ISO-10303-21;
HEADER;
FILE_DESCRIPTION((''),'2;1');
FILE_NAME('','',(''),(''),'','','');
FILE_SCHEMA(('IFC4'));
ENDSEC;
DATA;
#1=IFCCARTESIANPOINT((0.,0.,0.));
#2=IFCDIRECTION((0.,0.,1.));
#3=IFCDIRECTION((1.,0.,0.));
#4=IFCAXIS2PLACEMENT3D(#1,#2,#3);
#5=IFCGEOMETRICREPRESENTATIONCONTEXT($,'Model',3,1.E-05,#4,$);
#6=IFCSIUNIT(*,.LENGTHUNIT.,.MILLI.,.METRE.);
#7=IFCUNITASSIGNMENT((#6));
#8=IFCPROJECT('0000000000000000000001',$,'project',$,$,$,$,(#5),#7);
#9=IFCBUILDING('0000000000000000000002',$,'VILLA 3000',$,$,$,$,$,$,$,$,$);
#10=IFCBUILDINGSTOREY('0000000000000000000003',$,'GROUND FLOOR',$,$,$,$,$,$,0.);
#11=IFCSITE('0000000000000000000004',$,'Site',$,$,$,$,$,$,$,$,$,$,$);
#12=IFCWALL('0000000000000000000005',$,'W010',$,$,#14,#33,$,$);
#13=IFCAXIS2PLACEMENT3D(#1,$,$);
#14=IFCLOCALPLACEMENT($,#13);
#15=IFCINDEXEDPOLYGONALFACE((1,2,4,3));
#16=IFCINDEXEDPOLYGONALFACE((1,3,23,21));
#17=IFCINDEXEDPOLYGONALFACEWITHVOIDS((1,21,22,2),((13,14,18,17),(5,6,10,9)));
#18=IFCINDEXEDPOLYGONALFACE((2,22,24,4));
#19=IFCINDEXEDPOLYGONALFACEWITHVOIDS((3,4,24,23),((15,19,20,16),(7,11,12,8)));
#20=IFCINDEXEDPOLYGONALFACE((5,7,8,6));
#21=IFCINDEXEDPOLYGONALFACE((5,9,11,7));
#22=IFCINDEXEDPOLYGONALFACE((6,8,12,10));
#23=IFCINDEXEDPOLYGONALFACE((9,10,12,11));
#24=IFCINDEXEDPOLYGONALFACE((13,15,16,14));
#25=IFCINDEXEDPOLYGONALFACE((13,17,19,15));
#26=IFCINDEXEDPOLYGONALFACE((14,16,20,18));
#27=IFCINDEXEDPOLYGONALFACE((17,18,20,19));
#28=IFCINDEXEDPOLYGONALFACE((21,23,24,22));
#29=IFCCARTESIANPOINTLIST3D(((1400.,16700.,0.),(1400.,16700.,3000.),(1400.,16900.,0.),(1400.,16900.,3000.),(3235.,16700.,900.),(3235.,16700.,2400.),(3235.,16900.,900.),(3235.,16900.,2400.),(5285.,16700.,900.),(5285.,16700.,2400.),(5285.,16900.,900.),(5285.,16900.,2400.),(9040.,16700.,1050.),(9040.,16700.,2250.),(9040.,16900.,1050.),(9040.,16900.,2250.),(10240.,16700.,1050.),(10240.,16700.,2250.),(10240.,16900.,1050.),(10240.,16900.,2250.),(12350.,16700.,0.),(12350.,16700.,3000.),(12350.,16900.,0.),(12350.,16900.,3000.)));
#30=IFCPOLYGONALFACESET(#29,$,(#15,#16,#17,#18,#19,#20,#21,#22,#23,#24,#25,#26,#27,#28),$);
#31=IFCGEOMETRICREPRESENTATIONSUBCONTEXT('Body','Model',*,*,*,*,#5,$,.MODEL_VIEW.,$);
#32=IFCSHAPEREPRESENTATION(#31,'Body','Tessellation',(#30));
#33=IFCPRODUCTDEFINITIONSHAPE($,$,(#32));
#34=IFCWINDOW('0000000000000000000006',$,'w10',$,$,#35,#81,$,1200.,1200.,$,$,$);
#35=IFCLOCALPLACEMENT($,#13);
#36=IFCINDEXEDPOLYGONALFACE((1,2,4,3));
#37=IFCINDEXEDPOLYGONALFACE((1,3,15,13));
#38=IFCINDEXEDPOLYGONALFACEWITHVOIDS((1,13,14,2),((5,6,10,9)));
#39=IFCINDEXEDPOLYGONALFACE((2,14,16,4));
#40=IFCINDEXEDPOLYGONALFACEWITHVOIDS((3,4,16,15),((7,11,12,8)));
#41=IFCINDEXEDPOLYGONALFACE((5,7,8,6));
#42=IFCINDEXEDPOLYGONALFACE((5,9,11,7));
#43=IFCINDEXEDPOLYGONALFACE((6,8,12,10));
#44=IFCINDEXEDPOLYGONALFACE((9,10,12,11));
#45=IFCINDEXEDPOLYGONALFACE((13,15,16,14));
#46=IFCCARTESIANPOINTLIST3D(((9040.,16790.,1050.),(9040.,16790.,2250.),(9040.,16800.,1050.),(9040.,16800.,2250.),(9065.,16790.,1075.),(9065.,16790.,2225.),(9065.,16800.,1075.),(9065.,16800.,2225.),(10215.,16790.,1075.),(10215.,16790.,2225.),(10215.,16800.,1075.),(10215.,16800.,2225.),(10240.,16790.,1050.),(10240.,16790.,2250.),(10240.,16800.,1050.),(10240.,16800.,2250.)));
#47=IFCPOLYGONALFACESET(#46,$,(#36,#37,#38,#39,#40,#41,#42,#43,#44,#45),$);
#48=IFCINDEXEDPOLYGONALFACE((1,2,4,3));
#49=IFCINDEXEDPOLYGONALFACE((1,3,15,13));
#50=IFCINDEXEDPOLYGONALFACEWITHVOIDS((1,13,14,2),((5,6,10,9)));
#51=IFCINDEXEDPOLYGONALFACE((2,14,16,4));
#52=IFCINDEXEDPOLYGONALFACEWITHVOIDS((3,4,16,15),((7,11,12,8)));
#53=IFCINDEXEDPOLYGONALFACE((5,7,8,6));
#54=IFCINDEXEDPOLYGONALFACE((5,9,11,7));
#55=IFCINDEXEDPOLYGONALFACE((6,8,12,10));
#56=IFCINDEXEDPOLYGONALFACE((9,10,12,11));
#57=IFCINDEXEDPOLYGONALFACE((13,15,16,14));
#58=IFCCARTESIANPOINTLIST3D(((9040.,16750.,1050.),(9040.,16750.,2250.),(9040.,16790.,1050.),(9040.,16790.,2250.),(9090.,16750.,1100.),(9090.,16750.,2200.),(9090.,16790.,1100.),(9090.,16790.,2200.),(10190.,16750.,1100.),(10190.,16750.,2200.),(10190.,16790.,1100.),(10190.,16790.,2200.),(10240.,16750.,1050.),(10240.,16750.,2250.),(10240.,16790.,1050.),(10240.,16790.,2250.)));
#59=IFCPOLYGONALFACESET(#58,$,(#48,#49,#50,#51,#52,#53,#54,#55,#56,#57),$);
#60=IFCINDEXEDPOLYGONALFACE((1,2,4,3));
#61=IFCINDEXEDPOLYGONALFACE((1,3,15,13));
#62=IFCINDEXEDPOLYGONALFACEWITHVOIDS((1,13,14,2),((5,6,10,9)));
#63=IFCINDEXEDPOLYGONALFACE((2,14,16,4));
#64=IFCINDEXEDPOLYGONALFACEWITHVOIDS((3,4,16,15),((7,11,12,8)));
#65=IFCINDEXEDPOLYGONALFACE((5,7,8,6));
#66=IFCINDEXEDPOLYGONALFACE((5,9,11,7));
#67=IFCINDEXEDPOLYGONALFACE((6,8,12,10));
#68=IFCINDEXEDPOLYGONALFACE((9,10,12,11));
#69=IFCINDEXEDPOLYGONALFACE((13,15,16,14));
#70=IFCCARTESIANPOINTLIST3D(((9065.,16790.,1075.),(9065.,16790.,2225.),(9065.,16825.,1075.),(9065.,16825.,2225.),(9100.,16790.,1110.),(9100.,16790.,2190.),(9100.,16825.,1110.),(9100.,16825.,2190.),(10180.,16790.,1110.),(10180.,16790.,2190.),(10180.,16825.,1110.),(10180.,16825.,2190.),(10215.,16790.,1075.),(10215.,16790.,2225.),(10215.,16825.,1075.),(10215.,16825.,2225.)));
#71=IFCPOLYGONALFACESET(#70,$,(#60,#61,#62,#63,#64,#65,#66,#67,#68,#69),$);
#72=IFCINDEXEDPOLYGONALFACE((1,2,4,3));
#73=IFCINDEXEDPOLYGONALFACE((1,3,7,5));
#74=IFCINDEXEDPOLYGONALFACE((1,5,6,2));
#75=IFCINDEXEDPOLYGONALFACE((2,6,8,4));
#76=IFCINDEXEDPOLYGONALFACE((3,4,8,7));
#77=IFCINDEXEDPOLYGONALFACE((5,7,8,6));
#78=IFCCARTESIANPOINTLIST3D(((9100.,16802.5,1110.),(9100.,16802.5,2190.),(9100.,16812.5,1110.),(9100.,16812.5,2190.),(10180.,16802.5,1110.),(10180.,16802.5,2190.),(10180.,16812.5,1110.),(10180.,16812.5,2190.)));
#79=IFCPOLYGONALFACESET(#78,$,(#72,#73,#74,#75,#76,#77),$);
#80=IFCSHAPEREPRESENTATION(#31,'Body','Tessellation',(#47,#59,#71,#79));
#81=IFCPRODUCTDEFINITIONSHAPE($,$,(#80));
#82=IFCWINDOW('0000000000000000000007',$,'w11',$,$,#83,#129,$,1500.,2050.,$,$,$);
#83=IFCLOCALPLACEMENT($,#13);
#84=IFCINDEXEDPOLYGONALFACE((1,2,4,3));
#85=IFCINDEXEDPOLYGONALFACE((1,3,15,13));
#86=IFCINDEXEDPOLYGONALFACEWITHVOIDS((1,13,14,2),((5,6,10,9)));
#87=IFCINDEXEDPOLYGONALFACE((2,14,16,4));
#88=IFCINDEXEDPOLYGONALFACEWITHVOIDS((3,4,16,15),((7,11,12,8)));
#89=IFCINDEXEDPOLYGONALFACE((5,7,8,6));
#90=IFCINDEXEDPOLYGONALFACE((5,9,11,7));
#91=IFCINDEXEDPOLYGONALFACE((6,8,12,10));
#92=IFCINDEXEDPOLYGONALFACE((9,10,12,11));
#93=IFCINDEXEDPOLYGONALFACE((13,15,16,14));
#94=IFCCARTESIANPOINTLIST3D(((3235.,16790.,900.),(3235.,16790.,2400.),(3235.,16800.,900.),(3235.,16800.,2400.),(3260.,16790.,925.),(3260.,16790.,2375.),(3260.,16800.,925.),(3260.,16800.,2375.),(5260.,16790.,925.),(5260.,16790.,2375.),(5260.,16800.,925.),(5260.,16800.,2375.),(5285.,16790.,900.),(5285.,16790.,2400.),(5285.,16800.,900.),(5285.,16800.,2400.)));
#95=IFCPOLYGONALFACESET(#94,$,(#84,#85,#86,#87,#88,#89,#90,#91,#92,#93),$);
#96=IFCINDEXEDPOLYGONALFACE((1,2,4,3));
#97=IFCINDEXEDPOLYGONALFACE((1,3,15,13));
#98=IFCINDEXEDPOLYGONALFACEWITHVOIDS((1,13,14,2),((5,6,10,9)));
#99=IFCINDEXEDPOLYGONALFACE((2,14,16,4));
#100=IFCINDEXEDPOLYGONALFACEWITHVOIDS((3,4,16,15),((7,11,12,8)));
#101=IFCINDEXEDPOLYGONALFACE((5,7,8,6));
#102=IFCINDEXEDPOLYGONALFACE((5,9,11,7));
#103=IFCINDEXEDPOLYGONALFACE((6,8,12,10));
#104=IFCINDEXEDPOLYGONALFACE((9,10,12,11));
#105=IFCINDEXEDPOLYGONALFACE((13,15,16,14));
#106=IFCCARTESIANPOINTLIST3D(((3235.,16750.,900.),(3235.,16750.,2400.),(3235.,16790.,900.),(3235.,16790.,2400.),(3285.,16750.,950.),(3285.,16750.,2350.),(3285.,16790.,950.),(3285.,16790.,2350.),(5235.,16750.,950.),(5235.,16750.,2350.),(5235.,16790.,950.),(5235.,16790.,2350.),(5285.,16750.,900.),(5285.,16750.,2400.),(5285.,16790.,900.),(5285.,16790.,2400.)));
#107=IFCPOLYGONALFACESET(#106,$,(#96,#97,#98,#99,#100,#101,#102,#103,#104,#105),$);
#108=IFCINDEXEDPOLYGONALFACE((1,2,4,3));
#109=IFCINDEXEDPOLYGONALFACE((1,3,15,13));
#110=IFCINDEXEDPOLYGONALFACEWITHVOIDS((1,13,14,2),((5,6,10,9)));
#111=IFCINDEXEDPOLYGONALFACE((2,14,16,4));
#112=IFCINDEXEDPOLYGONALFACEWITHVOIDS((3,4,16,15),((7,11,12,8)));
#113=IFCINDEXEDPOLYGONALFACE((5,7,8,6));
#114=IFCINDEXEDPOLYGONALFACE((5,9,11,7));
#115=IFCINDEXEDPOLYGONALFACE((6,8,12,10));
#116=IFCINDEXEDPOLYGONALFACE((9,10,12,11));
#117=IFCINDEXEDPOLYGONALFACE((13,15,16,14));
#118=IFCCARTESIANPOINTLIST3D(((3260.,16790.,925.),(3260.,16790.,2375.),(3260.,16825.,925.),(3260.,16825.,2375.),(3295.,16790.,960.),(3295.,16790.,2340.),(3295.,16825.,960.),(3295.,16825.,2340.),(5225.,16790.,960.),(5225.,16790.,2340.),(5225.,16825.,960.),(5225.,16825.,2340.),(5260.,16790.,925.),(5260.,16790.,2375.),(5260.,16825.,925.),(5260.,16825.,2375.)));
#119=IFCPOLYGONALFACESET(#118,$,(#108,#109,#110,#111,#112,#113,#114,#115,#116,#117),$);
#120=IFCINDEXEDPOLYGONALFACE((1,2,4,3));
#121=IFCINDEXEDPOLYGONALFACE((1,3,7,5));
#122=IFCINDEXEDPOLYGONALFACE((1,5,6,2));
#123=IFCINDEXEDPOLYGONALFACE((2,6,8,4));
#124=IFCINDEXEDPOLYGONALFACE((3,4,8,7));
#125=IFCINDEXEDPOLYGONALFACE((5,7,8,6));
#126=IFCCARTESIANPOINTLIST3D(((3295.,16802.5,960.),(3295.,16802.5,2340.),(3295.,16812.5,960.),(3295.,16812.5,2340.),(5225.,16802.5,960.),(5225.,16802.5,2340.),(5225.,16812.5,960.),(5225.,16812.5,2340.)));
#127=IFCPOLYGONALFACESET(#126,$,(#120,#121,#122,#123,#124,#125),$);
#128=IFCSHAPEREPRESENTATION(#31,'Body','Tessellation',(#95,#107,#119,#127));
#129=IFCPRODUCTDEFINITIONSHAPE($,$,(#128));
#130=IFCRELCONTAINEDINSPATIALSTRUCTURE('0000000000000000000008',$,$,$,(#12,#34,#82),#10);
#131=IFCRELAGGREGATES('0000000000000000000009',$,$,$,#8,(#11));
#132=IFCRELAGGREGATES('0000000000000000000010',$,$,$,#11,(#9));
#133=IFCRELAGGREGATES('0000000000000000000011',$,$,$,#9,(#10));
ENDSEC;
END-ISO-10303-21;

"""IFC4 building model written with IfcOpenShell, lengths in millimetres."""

from ifc_helpers import new_model, si_unit, frame, origin_with_axes, place, context, subcontext, project, spatial, line, indexed_curve, outline, extrude, element, fill, save


model = new_model("IFC4")

# Units and contexts
model_context = context("Model", 3, precision=1e-05, world=origin_with_axes())
body_context = subcontext(model_context, "Body", "Model", "MODEL_VIEW")
ifc_project = project(units=[si_unit("LENGTHUNIT", "METRE", prefix="MILLI")], contexts=[model_context])

# Site, building, storey
site = spatial("IfcSite", under=ifc_project, Name="Site")
building = spatial("IfcBuilding", under=site, Name="VILLA 3000")
storey = spatial("IfcBuildingStorey", under=building, Name="GROUND FLOOR", Elevation=0.0)

# Wall, openings, windows
wall_1_placement = place(None, frame((1400.0, 16800.0, 0.0), z_axis=(0.0, 0.0, 1.0), x_axis=(1.0, 0.0, 0.0)))
wall_1 = element("IfcWall", 1, at=wall_1_placement, inside=storey, Name="W010", context=body_context, shape_type="SweptSolid", body=[
    extrude(outline(indexed_curve([(0.0, 0.0), (0.0, 200.0), (10950.0, 200.0), (10950.0, 0.0), (0.0, 0.0)], self_intersect=False)), frame((0.0, -100.0, 0.0), z_axis=(0.0, 0.0, 1.0), x_axis=(1.0, 0.0, 0.0)), (0.0, 0.0, 1.0), 3000.0),
])
opening_1_placement = place(wall_1_placement, frame((7640.0, 0.0, 1050.0), z_axis=(0.0, 0.0, 1.0), x_axis=(1.0, 0.0, 0.0)))
opening_1 = element("IfcOpeningElement", 2, at=opening_1_placement, cuts=wall_1, context=body_context, shape_type="SweptSolid", body=[
    extrude(outline(indexed_curve([(0.0, 0.0), (0.0, 300.0), (1200.0, 300.0), (1200.0, 0.0), (0.0, 0.0)], self_intersect=False)), frame((0.0, -150.0, 0.0), z_axis=(0.0, 0.0, 1.0), x_axis=(1.0, 0.0, 0.0)), (0.0, 0.0, 1.0), 1200.0),
])
opening_2_placement = place(wall_1_placement, frame((1835.0, 0.0, 900.0), z_axis=(0.0, 0.0, 1.0), x_axis=(1.0, 0.0, 0.0)))
opening_2 = element("IfcOpeningElement", 3, at=opening_2_placement, cuts=wall_1, context=body_context, shape_type="SweptSolid", body=[
    extrude(outline(indexed_curve([(0.0, 0.0), (0.0, 300.0), (2050.0, 300.0), (2050.0, 0.0), (0.0, 0.0)], self_intersect=False)), frame((0.0, -150.0, 0.0), z_axis=(0.0, 0.0, 1.0), x_axis=(1.0, 0.0, 0.0)), (0.0, 0.0, 1.0), 1500.0),
])
window_1_placement = place(None, frame((9040.0, 16700.0, 1050.0), z_axis=(0.0, 0.0, 1.0), x_axis=(1.0, 0.0, 0.0)))
window_1 = element("IfcWindow", 4, at=window_1_placement, inside=storey, Name="w10", OverallHeight=1200.0, OverallWidth=1200.0, context=body_context, shape_type="SweptSolid", body=[
    extrude(outline(indexed_curve([(0.0, 0.0), (1200.0, 0.0), (1200.0, 1200.0), (0.0, 1200.0)], segments=[line(1, 2, 3, 4, 1)]), holes=[indexed_curve([(25.0, 25.0), (1175.0, 25.0), (1175.0, 1175.0), (25.0, 1175.0)], segments=[line(1, 2, 3, 4, 1)])]), frame((0.0, 90.0, 0.0), z_axis=(0.0, -1.0, 0.0), x_axis=(1.0, 0.0, 0.0)), (0.0, 0.0, -1.0), 10.0),
    extrude(outline(indexed_curve([(0.0, 0.0), (1200.0, 0.0), (1200.0, 1200.0), (0.0, 1200.0)], segments=[line(1, 2, 3, 4, 1)]), holes=[indexed_curve([(50.0, 50.0), (1150.0, 50.0), (1150.0, 1150.0), (50.0, 1150.0)], segments=[line(1, 2, 3, 4, 1)])]), frame((0.0, 50.0, 0.0), z_axis=(0.0, -1.0, 0.0), x_axis=(1.0, 0.0, 0.0)), (0.0, 0.0, -1.0), 40.0),
    extrude(outline(indexed_curve([(0.0, 0.0), (1150.0, 0.0), (1150.0, 1150.0), (0.0, 1150.0)], segments=[line(1, 2, 3, 4, 1)]), holes=[indexed_curve([(35.0, 35.0), (1115.0, 35.0), (1115.0, 1115.0), (35.0, 1115.0)], segments=[line(1, 2, 3, 4, 1)])]), frame((25.0, 90.0, 25.0), z_axis=(0.0, -1.0, 0.0), x_axis=(1.0, 0.0, 0.0)), (0.0, 0.0, -1.0), 35.0),
    extrude(outline(indexed_curve([(35.0, 35.0), (1115.0, 35.0), (1115.0, 1115.0), (35.0, 1115.0)], segments=[line(1, 2, 3, 4, 1)])), frame((25.0, 102.5, 25.0), z_axis=(0.0, -1.0, 0.0), x_axis=(1.0, 0.0, 0.0)), (0.0, 0.0, -1.0), 10.0),
])
fill(opening_1, window_1)
window_2_placement = place(None, frame((3235.0, 16700.0, 900.0), z_axis=(0.0, 0.0, 1.0), x_axis=(1.0, 0.0, 0.0)))
window_2 = element("IfcWindow", 5, at=window_2_placement, inside=storey, Name="w11", OverallHeight=1500.0, OverallWidth=2050.0, context=body_context, shape_type="SweptSolid", body=[
    extrude(outline(indexed_curve([(0.0, 0.0), (2050.0, 0.0), (2050.0, 1500.0), (0.0, 1500.0)], segments=[line(1, 2, 3, 4, 1)]), holes=[indexed_curve([(25.0, 25.0), (2025.0, 25.0), (2025.0, 1475.0), (25.0, 1475.0)], segments=[line(1, 2, 3, 4, 1)])]), frame((0.0, 90.0, 0.0), z_axis=(0.0, -1.0, 0.0), x_axis=(1.0, 0.0, 0.0)), (0.0, 0.0, -1.0), 10.0),
    extrude(outline(indexed_curve([(0.0, 0.0), (2050.0, 0.0), (2050.0, 1500.0), (0.0, 1500.0)], segments=[line(1, 2, 3, 4, 1)]), holes=[indexed_curve([(50.0, 50.0), (2000.0, 50.0), (2000.0, 1450.0), (50.0, 1450.0)], segments=[line(1, 2, 3, 4, 1)])]), frame((0.0, 50.0, 0.0), z_axis=(0.0, -1.0, 0.0), x_axis=(1.0, 0.0, 0.0)), (0.0, 0.0, -1.0), 40.0),
    extrude(outline(indexed_curve([(0.0, 0.0), (2000.0, 0.0), (2000.0, 1450.0), (0.0, 1450.0)], segments=[line(1, 2, 3, 4, 1)]), holes=[indexed_curve([(35.0, 35.0), (1965.0, 35.0), (1965.0, 1415.0), (35.0, 1415.0)], segments=[line(1, 2, 3, 4, 1)])]), frame((25.0, 90.0, 25.0), z_axis=(0.0, -1.0, 0.0), x_axis=(1.0, 0.0, 0.0)), (0.0, 0.0, -1.0), 35.0),
    extrude(outline(indexed_curve([(35.0, 35.0), (1965.0, 35.0), (1965.0, 1415.0), (35.0, 1415.0)], segments=[line(1, 2, 3, 4, 1)])), frame((25.0, 102.5, 25.0), z_axis=(0.0, -1.0, 0.0), x_axis=(1.0, 0.0, 0.0)), (0.0, 0.0, -1.0), 10.0),
])
fill(opening_2, window_2)

save(model, "model.ifc")
